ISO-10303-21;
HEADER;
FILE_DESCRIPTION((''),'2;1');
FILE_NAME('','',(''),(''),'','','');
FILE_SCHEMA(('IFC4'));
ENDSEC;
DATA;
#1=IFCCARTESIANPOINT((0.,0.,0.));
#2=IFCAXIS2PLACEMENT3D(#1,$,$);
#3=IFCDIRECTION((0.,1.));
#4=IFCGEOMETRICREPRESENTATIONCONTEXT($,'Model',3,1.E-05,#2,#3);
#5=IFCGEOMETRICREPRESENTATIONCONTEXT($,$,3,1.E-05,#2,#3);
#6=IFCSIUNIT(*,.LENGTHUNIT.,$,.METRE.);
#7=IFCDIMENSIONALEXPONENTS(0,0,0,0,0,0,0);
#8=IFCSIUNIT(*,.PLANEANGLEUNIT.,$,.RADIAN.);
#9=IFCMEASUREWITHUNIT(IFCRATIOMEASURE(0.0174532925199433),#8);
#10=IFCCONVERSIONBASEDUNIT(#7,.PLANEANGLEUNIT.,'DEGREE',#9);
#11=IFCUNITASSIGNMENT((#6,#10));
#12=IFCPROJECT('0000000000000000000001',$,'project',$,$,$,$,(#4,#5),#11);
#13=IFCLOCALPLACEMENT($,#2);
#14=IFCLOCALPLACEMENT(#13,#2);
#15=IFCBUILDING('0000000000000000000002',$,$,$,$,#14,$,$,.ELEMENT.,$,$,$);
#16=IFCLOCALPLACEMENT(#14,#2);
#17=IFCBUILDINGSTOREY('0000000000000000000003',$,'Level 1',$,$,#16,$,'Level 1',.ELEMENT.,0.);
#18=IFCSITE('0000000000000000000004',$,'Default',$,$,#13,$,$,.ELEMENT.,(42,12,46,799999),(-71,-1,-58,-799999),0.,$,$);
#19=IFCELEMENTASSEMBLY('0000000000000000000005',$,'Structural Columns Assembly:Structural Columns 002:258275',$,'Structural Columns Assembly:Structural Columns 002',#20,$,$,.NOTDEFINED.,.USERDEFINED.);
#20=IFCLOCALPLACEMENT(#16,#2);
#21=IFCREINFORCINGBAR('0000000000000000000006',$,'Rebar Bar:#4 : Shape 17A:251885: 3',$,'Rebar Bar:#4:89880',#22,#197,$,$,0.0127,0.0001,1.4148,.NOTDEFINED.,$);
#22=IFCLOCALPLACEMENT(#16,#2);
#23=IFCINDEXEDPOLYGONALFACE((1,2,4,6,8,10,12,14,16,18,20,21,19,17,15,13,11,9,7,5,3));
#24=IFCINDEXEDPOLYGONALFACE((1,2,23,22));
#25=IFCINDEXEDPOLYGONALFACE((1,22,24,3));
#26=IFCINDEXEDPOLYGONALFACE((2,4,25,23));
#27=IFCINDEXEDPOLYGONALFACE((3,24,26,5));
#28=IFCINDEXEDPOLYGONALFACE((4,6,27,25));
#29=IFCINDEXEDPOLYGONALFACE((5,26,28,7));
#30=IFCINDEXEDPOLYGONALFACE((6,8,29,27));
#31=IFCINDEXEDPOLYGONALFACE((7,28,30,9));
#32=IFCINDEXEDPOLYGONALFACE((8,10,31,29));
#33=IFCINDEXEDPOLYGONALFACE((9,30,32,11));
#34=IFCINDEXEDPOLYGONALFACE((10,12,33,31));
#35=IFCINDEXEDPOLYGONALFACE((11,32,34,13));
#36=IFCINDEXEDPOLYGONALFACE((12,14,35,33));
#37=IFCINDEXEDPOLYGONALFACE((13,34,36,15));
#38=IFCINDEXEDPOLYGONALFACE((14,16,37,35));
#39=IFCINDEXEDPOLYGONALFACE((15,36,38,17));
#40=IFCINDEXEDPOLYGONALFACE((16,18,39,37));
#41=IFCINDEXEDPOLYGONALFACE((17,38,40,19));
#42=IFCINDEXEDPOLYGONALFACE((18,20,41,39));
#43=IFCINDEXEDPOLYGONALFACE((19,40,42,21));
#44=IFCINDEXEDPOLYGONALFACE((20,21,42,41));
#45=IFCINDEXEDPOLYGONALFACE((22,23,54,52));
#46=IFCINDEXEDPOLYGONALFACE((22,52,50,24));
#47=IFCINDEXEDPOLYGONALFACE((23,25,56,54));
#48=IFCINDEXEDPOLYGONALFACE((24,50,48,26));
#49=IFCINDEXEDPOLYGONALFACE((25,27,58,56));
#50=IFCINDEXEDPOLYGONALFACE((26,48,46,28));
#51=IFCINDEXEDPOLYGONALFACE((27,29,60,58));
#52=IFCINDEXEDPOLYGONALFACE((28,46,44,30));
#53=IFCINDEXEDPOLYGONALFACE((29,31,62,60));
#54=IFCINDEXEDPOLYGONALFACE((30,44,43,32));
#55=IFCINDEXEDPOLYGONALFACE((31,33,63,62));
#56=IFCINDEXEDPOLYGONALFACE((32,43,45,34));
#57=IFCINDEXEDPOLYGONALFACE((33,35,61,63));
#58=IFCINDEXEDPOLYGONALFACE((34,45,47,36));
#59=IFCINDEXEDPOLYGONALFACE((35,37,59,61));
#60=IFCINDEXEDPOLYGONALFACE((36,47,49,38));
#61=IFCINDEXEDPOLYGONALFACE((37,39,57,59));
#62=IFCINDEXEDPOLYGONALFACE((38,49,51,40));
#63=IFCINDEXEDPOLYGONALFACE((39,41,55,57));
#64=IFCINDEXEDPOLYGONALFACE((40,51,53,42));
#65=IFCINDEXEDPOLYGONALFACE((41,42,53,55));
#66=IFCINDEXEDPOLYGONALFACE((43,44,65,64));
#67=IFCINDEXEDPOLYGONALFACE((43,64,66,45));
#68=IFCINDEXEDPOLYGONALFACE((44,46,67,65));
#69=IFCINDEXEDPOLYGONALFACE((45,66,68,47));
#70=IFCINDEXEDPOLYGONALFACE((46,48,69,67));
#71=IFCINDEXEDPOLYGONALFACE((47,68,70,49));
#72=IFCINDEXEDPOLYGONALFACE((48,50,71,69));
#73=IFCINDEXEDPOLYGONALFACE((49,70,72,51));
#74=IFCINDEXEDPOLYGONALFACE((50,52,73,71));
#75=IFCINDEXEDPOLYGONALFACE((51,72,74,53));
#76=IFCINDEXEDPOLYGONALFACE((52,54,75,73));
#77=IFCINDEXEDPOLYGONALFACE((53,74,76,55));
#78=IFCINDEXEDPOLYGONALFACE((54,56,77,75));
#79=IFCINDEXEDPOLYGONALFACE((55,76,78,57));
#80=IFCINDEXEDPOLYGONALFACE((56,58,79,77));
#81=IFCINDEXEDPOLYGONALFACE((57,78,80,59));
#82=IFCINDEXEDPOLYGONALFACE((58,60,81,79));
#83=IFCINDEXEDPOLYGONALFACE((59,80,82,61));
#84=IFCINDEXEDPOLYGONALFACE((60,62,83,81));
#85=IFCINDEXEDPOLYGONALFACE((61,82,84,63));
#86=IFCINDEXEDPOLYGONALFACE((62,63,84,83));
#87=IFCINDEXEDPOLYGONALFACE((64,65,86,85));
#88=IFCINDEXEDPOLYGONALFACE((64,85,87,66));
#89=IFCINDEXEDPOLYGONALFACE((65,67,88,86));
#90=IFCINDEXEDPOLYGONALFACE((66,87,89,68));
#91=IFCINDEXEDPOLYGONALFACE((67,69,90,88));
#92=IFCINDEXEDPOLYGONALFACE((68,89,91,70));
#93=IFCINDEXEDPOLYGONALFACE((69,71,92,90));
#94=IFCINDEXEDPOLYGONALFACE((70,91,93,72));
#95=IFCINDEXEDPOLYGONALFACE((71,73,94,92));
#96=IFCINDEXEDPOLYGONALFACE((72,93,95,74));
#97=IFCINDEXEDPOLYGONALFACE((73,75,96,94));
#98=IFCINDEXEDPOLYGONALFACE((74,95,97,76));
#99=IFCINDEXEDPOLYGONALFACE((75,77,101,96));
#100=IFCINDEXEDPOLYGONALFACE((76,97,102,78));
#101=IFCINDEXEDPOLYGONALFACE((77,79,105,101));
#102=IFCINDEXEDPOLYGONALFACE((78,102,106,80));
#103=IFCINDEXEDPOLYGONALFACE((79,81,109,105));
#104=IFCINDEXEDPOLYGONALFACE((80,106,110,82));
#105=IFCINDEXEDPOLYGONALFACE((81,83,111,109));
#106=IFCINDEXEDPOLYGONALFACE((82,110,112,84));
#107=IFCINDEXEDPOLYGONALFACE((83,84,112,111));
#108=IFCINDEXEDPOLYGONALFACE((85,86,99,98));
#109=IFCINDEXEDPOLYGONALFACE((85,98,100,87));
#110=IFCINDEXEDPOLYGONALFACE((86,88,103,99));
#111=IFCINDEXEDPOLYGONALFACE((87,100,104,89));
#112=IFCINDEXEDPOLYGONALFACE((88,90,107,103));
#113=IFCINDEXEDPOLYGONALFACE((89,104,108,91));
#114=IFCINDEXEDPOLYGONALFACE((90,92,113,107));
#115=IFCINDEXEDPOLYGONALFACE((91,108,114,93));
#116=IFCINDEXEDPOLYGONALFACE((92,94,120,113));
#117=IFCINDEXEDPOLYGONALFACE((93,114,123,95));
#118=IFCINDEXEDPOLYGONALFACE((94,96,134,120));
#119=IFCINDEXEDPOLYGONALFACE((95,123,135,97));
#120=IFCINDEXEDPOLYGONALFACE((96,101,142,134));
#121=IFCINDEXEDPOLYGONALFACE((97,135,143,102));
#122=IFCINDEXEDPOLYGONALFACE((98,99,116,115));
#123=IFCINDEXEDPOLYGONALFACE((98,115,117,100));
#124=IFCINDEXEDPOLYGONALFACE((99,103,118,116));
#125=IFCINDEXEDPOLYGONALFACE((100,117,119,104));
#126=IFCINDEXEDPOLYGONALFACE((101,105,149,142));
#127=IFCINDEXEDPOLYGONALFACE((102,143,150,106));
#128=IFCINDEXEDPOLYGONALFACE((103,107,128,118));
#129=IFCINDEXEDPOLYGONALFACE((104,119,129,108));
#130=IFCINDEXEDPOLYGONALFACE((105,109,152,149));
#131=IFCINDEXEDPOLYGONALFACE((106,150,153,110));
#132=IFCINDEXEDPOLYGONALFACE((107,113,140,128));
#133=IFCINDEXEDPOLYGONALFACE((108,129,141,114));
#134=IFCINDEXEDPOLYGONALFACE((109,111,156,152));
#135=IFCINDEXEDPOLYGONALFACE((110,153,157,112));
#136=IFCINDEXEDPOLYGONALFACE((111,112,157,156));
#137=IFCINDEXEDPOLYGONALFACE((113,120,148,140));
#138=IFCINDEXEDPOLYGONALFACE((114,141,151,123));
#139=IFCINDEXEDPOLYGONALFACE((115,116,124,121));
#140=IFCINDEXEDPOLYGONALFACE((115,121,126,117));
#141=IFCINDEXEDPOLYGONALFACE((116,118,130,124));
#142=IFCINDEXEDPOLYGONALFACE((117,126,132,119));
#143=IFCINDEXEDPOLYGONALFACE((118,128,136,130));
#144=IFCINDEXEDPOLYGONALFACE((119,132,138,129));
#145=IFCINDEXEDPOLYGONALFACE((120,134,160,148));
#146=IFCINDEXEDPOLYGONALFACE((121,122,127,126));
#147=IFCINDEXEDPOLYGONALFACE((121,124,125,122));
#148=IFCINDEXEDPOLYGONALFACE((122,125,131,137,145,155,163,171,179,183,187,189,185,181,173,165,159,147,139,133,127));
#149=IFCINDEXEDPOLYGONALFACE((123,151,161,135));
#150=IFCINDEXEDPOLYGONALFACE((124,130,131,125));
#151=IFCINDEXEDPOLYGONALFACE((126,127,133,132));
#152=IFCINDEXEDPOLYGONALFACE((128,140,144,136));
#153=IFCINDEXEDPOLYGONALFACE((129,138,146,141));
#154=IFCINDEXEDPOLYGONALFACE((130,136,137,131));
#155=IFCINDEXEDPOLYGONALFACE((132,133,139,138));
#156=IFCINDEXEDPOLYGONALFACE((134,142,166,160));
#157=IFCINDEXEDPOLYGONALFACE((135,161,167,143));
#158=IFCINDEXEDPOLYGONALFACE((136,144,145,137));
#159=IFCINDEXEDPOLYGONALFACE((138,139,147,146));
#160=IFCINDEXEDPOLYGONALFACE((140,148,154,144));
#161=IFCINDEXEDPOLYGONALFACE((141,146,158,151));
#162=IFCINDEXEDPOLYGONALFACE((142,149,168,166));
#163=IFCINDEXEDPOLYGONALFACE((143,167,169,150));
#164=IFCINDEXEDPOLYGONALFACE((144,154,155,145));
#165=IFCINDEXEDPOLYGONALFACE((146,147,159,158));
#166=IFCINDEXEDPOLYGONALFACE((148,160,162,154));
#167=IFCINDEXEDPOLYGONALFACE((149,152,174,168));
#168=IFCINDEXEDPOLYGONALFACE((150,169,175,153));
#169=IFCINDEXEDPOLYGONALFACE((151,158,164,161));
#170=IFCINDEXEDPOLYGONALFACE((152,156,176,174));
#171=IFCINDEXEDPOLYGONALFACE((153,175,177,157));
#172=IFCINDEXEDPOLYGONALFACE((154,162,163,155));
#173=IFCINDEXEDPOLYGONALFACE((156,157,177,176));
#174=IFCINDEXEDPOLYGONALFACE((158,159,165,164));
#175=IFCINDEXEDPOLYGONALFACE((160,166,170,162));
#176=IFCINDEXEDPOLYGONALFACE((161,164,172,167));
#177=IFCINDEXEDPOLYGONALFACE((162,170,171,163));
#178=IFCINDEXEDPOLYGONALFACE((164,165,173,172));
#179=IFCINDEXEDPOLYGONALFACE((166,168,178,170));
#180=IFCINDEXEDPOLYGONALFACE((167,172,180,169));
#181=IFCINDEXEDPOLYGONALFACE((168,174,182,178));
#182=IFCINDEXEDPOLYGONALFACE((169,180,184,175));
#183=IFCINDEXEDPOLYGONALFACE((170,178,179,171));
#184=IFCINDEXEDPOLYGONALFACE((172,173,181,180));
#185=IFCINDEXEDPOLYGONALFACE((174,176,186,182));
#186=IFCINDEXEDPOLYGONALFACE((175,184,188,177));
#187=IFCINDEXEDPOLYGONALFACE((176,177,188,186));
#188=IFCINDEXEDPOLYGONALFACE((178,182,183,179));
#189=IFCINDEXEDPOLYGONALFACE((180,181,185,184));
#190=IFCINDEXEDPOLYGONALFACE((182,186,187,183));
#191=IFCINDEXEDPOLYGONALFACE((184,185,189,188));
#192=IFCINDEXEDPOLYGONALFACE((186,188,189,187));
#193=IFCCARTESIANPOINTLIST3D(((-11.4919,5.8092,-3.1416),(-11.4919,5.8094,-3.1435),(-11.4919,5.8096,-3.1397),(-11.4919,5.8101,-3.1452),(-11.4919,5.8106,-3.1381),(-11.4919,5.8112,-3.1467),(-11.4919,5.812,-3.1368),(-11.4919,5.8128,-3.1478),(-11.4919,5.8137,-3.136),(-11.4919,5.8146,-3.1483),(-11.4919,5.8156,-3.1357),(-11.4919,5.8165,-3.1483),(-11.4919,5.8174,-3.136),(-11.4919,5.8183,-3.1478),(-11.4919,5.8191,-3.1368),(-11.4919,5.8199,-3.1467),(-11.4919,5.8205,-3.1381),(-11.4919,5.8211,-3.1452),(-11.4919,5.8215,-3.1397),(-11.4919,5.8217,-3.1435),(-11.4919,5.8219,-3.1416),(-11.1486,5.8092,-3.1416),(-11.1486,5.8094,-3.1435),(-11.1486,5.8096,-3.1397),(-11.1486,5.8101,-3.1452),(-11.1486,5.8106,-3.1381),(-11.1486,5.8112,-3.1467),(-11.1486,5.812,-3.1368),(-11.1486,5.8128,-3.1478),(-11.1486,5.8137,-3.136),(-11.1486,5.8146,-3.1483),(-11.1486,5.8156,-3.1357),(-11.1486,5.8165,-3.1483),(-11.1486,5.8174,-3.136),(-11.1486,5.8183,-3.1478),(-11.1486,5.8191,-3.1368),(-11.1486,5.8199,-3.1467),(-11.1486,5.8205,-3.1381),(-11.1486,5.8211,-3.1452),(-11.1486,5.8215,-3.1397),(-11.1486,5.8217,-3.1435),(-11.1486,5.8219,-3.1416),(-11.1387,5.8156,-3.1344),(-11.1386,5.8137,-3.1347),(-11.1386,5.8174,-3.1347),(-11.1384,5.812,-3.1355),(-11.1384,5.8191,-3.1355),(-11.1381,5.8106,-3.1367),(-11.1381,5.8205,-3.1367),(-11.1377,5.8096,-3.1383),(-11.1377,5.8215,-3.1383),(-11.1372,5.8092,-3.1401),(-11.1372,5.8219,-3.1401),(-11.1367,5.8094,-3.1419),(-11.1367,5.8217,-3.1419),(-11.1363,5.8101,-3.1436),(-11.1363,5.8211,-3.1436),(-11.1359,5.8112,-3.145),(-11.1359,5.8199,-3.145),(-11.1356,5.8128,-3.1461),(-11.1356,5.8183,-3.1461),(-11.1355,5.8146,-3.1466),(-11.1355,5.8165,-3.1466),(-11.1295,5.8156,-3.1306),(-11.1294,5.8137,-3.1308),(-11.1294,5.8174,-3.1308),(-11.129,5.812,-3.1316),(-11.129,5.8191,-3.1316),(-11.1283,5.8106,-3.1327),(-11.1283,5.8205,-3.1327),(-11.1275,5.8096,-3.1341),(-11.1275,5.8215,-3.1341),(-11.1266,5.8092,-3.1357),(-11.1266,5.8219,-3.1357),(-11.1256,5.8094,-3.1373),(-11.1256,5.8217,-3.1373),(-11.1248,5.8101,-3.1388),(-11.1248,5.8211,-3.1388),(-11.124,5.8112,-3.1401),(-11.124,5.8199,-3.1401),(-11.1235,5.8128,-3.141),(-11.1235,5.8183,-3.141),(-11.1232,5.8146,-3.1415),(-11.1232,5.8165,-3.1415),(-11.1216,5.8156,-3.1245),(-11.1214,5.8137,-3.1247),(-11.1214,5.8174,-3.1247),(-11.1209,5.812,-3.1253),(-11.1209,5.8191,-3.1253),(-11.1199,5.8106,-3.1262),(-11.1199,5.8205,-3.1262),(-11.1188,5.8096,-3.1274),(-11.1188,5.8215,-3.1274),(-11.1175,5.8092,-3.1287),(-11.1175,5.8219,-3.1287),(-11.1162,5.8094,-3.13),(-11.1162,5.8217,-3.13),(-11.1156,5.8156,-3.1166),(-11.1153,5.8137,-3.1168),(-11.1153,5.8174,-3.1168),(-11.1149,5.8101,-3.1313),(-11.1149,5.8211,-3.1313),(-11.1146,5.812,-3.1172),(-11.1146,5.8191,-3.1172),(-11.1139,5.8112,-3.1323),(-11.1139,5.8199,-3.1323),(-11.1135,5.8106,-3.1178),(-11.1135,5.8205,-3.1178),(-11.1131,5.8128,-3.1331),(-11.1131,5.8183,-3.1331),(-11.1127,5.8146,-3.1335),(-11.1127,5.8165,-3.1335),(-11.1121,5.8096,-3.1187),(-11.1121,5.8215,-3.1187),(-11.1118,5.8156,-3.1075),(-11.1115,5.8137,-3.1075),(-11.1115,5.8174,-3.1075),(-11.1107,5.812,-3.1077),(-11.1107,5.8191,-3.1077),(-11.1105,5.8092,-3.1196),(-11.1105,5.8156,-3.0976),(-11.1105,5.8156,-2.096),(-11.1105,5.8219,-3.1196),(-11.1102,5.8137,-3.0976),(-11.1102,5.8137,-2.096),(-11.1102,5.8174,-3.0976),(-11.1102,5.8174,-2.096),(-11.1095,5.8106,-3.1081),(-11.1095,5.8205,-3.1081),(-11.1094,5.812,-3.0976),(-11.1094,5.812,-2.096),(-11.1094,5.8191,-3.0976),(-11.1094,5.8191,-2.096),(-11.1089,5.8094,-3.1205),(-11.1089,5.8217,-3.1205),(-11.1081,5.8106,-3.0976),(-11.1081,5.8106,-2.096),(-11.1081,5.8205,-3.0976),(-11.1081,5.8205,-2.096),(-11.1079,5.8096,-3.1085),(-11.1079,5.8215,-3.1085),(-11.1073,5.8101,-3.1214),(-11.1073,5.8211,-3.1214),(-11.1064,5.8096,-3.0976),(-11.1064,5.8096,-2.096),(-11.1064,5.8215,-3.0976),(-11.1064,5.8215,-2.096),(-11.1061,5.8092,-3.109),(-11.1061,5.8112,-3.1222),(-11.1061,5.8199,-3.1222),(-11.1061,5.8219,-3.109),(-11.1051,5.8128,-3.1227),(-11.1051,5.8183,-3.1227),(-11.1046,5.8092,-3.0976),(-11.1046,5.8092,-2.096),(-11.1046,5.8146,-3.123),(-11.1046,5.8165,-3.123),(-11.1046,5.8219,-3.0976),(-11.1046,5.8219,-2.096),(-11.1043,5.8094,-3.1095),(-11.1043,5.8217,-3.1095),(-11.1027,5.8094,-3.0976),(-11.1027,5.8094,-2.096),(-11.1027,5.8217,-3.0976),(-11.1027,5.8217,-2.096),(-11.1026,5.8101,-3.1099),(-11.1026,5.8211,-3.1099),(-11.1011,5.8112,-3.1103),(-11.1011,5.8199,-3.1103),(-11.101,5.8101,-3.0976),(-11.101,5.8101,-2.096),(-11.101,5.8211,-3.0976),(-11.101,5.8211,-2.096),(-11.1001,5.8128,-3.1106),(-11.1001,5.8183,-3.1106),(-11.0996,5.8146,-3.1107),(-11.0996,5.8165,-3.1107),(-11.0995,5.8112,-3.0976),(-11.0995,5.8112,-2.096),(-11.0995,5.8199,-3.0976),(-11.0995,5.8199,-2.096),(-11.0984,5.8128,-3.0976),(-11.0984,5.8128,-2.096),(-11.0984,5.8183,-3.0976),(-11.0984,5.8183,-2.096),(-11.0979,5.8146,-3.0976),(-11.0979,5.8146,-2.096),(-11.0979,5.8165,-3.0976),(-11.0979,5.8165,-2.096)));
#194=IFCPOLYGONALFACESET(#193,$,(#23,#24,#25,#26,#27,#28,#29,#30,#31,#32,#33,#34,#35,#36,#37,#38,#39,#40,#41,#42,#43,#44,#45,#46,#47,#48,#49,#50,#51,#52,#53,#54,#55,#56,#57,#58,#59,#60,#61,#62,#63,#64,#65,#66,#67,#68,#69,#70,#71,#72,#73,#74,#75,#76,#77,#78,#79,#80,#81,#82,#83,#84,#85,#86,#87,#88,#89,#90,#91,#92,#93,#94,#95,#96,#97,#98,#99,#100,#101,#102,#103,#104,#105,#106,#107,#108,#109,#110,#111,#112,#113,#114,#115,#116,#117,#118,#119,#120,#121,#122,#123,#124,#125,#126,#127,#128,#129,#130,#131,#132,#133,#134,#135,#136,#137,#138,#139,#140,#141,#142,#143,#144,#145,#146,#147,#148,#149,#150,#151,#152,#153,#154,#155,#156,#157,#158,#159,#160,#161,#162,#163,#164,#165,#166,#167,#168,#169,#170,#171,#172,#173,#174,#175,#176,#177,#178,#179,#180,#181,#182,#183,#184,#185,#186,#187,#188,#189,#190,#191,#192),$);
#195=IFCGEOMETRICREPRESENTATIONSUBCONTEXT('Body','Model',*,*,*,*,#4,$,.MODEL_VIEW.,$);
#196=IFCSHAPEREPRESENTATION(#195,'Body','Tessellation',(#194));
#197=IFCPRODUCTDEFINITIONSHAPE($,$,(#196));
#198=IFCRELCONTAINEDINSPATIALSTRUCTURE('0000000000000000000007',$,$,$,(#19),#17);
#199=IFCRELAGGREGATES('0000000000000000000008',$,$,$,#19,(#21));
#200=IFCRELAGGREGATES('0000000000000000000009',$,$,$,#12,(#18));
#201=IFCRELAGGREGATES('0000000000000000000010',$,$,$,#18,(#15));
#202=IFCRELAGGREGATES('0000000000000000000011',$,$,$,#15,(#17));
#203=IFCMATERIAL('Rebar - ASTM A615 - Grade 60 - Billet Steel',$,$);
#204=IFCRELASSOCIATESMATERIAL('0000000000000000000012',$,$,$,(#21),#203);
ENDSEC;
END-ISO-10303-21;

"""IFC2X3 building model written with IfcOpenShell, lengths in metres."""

from ifc_helpers import new_model, entity, si_unit, converted_unit, direction, origin, place, context, subcontext, project, spatial, material, element, aggregate, save


model = new_model("IFC2X3")

# Units and contexts
model_context = context("Model", 3, precision=1e-05, world=origin(), true_north=direction((0.0, 1.0)))
context_of_model = context(None, 3, precision=1e-05, world=origin(), true_north=direction((0.0, 1.0)))
body_context = subcontext(model_context, "Body", "Model", "MODEL_VIEW")
ifc_project = project(units=[si_unit("LENGTHUNIT", "METRE"), converted_unit("PLANEANGLEUNIT", "DEGREE", entity("IfcRatioMeasure", 0.0174532925199433), si_unit("PLANEANGLEUNIT", "RADIAN"), dimensions=[0, 0, 0, 0, 0, 0, 0])], contexts=[model_context, context_of_model])

# Site, building, storey
site_placement = place(None, origin())
site = spatial("IfcSite", under=ifc_project, at=site_placement, Name="Default", CompositionType="ELEMENT", RefLatitude=(42, 12, 46, 799999), RefLongitude=(-71, -1, -58, -799999), RefElevation=0.0)
building_placement = place(site_placement, origin())
building = spatial("IfcBuilding", under=site, at=building_placement, CompositionType="ELEMENT")
storey_placement = place(building_placement, origin())
storey = spatial("IfcBuildingStorey", under=building, at=storey_placement, Name="Level 1", LongName="Level 1", CompositionType="ELEMENT", Elevation=0.0)

# Element assembly, reinforcing bar
assembly_1_placement = place(storey_placement, origin())
assembly_1 = element("IfcElementAssembly", 1, at=assembly_1_placement, inside=storey, Name="Structural Columns Assembly:Structural Columns 002:258275", ObjectType="Structural Columns Assembly:Structural Columns 002", AssemblyPlace="NOTDEFINED", PredefinedType="USERDEFINED")
ifc_material_1 = material(Name="Rebar - ASTM A615 - Grade 60 - Billet Steel")
reinforcing_bar_1_placement = place(assembly_1_placement, origin())
reinforcing_bar_1 = element("IfcReinforcingBar", 2, at=reinforcing_bar_1_placement, material=ifc_material_1, Name="Rebar Bar:#4 : Shape 17A:251885: 3", ObjectType="Rebar Bar:#4:89880", BarLength=1.4148, BarRole="NOTDEFINED", CrossSectionArea=0.0001, NominalDiameter=0.0127, context=body_context, shape_type="AdvancedSweptSolid", body=[
    entity("IfcSweptDiskSolid", entity("IfcCompositeCurve", [entity("IfcCompositeCurveSegment", "CONTINUOUS", True, entity("IfcPolyline", [entity("IfcCartesianPoint", [-11.4919, 5.8156, -3.142]), entity("IfcCartesianPoint", [-11.1486, 5.8156, -3.142])])), entity("IfcCompositeCurveSegment", "CONTINUOUS", True, entity("IfcTrimmedCurve", entity("IfcCircle", entity("IfcAxis2Placement3D", entity("IfcCartesianPoint", [-11.1486, 5.8156, -3.0976]), entity("IfcDirection", [0.0, -1.0, 0.0]), entity("IfcDirection", [1.0, 0.0, 0.0])), 0.0445), [entity("IfcParameterValue", 270.0)], [entity("IfcParameterValue", 360.0)], True, "PARAMETER")), entity("IfcCompositeCurveSegment", "CONTINUOUS", True, entity("IfcPolyline", [entity("IfcCartesianPoint", [-11.1041, 5.8156, -3.0976]), entity("IfcCartesianPoint", [-11.1041, 5.8156, -2.096])]))], False), 0.0063, None, 0.0, 92.0),
])
aggregate(assembly_1, [reinforcing_bar_1])

save(model, "model.ifc")
